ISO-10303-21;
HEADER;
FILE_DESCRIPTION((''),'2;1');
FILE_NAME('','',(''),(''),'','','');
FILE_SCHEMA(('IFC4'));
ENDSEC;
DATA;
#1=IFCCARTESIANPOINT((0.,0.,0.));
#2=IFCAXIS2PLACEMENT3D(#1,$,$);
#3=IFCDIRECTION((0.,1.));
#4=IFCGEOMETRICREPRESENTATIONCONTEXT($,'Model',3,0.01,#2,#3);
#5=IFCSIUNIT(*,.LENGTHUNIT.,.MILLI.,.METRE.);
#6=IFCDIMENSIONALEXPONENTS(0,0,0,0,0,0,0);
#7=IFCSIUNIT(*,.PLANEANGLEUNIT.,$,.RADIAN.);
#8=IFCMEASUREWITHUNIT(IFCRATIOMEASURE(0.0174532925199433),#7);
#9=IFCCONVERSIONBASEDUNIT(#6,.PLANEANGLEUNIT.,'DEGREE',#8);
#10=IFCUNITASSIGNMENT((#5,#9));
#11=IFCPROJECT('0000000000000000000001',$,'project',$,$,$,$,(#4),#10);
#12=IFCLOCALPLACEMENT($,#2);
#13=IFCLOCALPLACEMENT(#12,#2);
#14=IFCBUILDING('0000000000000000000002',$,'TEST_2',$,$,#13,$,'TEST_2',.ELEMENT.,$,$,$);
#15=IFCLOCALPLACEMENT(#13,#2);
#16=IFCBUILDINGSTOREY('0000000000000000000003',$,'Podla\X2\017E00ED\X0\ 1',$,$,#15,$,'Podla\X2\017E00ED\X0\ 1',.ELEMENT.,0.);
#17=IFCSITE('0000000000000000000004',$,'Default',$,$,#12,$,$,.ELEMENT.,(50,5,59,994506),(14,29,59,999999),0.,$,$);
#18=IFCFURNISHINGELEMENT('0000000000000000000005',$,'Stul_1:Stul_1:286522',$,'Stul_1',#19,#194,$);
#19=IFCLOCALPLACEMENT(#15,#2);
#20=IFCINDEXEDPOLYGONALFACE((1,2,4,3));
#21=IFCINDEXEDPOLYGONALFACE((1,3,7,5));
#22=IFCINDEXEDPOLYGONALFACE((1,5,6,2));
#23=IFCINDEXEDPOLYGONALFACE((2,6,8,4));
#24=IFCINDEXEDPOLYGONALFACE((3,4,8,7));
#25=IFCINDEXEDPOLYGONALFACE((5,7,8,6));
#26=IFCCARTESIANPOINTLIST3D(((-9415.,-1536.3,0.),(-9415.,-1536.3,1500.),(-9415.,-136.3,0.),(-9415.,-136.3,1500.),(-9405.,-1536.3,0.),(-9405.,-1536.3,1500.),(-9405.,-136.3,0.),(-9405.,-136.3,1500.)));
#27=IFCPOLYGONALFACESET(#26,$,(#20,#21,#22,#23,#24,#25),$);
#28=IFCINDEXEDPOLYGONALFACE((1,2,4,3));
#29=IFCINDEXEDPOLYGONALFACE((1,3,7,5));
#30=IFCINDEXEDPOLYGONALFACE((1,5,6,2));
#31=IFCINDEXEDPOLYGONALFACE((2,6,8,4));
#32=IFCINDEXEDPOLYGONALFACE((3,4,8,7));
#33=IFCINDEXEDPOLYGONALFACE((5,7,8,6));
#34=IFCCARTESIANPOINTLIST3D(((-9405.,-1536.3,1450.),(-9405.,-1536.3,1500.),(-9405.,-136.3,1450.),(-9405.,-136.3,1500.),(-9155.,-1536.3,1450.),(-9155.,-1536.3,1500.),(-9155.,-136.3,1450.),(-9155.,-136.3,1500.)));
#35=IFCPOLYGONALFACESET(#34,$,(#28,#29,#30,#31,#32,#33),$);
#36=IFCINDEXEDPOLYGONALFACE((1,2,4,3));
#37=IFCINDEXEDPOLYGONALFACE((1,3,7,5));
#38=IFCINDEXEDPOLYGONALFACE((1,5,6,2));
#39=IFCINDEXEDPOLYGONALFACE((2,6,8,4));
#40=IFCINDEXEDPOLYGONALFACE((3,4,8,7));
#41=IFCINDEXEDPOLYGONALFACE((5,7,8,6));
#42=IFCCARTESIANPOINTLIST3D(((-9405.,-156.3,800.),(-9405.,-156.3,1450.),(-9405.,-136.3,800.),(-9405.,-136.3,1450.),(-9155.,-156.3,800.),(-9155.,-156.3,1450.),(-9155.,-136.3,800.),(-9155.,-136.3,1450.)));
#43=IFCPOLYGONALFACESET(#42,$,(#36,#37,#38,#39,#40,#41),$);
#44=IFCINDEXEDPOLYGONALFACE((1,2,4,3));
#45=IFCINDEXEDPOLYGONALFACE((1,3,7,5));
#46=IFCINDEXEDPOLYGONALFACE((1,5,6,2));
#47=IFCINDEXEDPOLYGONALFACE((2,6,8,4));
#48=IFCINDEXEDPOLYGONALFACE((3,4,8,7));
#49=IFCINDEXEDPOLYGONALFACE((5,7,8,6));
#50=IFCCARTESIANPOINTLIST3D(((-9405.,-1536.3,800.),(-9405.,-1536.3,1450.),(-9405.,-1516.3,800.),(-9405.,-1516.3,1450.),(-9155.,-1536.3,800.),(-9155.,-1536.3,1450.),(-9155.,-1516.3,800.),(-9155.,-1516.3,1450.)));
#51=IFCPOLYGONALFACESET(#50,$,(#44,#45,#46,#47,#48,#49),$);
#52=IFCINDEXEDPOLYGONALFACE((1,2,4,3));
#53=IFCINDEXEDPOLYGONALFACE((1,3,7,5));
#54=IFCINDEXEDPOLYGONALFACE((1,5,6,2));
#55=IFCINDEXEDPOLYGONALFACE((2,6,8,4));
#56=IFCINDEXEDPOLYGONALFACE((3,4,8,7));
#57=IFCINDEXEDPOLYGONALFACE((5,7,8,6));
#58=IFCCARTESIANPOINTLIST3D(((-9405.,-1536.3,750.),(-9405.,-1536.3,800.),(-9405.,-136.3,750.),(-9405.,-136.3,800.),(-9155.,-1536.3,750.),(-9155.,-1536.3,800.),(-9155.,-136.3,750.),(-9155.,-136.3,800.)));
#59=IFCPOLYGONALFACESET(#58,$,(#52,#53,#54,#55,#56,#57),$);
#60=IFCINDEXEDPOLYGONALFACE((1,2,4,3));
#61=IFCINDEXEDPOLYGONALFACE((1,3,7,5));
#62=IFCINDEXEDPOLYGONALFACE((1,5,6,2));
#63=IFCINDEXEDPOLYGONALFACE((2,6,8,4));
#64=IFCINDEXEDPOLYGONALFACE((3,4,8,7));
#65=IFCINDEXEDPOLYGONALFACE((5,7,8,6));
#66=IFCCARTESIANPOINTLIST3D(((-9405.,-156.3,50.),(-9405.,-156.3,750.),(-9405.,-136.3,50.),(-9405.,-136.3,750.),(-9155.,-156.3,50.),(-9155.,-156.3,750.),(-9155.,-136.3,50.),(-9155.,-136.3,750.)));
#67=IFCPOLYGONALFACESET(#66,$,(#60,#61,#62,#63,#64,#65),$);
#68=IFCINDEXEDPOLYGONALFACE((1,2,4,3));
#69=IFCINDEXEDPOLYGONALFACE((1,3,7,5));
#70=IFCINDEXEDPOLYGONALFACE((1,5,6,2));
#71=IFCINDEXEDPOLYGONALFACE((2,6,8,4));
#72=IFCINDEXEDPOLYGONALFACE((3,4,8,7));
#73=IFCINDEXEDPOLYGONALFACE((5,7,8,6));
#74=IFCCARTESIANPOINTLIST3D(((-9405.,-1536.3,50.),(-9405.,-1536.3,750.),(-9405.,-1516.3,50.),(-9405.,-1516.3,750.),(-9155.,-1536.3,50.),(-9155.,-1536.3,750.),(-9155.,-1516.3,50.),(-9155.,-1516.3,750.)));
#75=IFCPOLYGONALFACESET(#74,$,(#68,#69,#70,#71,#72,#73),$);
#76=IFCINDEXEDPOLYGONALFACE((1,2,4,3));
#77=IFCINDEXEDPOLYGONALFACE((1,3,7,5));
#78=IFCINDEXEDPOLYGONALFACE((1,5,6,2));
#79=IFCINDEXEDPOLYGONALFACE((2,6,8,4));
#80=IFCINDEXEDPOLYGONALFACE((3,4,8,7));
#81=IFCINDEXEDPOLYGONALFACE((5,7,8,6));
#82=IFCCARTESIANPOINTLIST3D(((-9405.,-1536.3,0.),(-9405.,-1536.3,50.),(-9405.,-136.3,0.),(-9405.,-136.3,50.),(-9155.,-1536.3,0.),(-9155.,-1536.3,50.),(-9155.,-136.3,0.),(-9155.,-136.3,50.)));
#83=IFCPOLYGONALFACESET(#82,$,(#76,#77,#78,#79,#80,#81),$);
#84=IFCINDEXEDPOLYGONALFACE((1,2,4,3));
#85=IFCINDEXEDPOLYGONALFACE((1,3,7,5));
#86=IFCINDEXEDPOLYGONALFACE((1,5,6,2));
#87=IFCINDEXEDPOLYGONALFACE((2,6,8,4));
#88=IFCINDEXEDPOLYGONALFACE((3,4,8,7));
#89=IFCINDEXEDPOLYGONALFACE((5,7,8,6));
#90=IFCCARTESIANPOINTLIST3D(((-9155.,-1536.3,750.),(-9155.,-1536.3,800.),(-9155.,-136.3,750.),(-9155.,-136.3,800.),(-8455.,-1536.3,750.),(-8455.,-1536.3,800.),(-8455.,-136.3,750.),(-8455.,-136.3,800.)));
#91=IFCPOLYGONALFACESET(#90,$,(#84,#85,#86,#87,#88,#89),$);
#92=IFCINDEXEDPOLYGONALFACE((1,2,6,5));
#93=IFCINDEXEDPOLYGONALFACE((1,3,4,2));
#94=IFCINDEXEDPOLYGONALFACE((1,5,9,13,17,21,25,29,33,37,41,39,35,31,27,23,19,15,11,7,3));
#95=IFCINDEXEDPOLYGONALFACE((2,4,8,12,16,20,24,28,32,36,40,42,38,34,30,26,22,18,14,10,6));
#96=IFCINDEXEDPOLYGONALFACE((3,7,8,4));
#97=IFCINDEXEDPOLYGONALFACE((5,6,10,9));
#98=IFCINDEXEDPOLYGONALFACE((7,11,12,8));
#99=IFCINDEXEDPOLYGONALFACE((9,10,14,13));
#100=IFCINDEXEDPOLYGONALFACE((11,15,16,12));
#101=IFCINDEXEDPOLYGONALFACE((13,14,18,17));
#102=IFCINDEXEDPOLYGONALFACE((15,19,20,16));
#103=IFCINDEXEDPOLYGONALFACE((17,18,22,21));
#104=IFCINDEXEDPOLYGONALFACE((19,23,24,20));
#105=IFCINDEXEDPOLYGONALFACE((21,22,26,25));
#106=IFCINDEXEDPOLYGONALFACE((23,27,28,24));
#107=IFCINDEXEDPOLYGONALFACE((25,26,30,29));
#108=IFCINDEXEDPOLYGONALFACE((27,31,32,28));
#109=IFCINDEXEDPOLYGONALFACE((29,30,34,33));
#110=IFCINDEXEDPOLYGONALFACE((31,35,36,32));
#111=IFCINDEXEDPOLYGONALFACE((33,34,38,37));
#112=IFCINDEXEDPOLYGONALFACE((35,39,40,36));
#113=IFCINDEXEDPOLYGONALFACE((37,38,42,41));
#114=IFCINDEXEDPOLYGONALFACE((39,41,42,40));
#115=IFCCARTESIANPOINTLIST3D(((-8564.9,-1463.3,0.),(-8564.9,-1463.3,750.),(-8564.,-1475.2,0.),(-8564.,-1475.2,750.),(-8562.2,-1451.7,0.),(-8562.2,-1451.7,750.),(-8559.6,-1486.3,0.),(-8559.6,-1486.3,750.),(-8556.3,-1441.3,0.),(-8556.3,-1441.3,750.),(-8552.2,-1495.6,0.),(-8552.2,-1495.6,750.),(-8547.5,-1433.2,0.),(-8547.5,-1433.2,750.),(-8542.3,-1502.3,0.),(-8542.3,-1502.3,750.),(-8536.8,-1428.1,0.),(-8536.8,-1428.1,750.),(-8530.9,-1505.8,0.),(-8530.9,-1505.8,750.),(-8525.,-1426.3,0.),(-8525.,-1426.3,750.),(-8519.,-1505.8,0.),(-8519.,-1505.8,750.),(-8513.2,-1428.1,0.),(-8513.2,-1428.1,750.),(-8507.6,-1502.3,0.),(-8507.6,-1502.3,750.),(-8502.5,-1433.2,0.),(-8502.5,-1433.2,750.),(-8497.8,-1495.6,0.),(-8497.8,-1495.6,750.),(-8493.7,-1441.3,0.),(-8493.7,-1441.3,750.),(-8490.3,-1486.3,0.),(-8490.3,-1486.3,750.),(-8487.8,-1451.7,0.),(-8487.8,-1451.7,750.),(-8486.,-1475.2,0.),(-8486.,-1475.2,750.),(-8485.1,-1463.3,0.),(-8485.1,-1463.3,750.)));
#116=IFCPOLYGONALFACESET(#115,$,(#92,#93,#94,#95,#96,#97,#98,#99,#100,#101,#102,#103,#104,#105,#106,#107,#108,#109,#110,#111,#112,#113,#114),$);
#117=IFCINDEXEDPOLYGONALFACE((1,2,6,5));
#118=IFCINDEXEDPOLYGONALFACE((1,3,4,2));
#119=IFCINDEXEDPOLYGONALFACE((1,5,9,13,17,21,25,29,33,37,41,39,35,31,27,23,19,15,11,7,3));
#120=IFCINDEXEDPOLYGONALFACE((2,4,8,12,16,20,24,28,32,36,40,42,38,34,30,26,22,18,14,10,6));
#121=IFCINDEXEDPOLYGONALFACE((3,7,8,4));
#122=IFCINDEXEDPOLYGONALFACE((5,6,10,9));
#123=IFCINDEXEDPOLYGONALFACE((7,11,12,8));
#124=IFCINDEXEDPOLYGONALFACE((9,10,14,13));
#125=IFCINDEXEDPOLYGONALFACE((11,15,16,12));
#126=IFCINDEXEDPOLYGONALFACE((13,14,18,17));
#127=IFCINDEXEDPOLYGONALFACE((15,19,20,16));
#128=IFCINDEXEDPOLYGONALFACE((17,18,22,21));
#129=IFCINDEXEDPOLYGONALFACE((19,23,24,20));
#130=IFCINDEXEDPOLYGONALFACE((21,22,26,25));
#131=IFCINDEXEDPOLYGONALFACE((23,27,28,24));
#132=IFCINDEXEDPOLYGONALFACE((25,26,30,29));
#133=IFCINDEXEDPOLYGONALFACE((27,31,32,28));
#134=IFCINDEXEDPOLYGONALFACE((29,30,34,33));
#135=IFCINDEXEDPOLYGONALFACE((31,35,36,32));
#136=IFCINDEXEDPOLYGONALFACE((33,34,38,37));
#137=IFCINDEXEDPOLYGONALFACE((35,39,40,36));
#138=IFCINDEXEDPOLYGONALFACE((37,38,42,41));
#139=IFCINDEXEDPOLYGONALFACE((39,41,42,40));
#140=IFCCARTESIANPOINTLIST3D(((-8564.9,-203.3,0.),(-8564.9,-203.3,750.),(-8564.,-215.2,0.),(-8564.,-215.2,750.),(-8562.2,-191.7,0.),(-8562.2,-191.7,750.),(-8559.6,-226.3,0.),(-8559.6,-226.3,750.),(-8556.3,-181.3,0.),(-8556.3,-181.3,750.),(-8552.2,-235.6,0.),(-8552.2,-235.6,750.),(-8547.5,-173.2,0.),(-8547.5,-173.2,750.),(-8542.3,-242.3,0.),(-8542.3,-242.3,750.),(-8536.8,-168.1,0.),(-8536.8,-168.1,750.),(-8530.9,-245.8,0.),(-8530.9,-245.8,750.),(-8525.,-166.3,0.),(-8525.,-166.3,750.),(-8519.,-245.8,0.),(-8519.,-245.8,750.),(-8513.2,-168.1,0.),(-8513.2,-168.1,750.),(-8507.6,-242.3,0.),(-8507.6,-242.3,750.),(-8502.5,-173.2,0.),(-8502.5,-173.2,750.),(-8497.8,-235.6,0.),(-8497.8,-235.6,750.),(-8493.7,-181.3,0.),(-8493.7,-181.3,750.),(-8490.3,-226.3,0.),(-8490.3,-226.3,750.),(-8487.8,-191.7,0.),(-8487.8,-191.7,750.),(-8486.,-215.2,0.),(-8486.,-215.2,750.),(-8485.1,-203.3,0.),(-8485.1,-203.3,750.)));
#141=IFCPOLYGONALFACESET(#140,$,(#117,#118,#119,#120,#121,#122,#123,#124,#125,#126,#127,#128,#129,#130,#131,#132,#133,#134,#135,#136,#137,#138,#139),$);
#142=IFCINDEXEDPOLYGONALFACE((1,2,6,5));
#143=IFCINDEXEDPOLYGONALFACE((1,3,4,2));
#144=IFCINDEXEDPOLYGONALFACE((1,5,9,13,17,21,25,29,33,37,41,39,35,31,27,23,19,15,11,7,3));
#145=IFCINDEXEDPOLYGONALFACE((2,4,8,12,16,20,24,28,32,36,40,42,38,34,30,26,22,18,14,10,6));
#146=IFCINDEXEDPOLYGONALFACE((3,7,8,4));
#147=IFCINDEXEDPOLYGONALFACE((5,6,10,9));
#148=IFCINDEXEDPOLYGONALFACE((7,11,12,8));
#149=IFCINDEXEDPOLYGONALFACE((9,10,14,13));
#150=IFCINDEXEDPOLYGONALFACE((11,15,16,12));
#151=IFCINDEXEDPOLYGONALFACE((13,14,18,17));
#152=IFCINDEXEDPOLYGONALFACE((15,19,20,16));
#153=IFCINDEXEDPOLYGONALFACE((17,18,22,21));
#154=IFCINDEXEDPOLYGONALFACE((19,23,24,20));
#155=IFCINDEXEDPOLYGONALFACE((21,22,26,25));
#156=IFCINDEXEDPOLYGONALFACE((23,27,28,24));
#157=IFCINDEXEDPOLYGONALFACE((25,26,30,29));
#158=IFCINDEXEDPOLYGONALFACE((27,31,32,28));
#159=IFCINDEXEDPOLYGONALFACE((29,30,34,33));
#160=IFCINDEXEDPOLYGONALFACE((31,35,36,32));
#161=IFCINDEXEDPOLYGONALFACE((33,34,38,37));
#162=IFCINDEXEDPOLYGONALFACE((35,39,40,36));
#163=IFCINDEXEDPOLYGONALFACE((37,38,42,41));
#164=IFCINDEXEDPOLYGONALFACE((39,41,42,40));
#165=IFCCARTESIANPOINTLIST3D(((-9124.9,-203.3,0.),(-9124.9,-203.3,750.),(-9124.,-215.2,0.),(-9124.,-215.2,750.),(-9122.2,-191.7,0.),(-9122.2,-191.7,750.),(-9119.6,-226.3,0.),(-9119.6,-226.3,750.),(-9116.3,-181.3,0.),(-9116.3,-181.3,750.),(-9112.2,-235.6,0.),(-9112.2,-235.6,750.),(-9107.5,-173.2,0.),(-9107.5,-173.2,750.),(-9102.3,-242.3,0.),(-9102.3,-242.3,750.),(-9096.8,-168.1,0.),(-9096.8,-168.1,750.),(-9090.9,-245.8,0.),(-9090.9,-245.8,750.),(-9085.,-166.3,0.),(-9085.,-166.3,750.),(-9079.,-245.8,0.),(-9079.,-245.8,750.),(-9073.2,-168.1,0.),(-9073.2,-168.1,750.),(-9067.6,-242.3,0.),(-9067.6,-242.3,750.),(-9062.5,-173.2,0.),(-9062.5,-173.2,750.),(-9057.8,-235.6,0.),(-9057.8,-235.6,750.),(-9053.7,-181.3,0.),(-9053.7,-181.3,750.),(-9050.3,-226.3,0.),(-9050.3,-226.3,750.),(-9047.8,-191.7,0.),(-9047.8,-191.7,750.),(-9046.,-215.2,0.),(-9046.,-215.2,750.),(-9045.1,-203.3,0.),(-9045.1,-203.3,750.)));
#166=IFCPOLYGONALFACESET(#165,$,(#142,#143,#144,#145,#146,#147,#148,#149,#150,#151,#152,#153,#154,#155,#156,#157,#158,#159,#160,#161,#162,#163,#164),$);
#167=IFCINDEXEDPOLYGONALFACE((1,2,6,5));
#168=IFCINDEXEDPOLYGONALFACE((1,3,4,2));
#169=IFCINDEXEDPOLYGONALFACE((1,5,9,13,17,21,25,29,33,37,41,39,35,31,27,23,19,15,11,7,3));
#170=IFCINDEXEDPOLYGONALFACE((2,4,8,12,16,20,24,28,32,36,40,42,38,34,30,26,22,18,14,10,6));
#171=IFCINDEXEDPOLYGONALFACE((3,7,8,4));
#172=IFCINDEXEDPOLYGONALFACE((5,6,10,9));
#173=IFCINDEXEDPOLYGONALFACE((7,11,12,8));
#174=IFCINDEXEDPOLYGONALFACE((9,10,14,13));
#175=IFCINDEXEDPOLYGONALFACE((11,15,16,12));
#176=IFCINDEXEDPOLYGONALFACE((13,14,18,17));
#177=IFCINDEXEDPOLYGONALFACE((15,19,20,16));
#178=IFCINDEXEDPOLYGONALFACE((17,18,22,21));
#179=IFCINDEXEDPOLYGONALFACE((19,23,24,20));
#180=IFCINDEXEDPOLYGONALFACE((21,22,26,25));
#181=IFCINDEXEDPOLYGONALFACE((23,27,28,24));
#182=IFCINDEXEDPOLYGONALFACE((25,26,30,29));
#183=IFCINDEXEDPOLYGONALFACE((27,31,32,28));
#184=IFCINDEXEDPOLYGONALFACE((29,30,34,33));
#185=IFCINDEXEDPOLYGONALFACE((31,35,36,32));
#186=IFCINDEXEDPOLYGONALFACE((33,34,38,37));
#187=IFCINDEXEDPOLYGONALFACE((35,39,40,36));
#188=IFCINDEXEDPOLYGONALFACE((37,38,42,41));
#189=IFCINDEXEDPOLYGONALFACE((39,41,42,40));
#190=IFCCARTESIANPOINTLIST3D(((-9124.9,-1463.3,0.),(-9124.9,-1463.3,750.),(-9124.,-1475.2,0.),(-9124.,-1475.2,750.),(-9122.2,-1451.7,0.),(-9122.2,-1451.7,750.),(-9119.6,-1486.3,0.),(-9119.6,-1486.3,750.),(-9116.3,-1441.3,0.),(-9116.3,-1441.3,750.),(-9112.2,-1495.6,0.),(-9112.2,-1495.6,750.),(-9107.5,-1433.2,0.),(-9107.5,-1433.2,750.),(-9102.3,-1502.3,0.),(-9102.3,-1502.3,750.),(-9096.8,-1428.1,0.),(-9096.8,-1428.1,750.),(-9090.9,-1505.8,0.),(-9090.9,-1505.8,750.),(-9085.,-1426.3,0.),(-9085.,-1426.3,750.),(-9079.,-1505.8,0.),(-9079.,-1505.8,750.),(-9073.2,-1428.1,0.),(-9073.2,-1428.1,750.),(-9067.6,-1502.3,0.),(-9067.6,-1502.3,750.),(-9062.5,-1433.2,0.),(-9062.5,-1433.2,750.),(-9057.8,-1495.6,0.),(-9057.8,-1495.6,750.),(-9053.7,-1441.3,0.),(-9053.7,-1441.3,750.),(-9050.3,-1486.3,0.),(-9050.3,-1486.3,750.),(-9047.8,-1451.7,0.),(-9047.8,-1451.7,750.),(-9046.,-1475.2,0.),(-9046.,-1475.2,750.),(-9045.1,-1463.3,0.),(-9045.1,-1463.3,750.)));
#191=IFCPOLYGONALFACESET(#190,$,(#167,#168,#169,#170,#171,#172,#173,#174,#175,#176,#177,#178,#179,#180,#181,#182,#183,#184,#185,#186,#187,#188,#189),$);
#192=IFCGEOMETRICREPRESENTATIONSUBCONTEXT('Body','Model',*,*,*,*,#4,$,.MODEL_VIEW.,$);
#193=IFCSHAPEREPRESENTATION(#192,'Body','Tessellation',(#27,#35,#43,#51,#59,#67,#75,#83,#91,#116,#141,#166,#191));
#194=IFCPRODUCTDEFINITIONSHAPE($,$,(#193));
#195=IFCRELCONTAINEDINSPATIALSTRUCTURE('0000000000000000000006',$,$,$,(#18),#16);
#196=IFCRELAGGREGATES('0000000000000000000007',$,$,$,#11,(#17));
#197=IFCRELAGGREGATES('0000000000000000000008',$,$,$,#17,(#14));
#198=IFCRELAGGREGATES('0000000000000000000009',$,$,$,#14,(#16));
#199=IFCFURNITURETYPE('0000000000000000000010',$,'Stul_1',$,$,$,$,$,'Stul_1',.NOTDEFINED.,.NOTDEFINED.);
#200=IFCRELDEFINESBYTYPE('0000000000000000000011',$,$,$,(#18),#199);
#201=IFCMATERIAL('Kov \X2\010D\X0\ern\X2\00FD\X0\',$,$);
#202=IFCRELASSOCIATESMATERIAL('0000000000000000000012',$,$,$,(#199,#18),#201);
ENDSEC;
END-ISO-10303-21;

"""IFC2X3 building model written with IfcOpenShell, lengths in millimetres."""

from ifc_helpers import new_model, entity, si_unit, converted_unit, direction, frame, frame_2d, origin, origin_2d_with_axis, place, context, subcontext, project, spatial, rectangle, circle, extrude, source, transform, mapped, material, type_object, type_shapes, element, save


model = new_model("IFC2X3")

# Units and contexts
model_context = context("Model", 3, precision=0.01, world=origin(), true_north=direction((0.0, 1.0)))
body_context = subcontext(model_context, "Body", "Model", "MODEL_VIEW")
ifc_project = project(units=[si_unit("LENGTHUNIT", "METRE", prefix="MILLI"), converted_unit("PLANEANGLEUNIT", "DEGREE", entity("IfcRatioMeasure", 0.0174532925199433), si_unit("PLANEANGLEUNIT", "RADIAN"), dimensions=[0, 0, 0, 0, 0, 0, 0])], contexts=[model_context])

# Site, building, storey
site_placement = place(None, origin())
site = spatial("IfcSite", under=ifc_project, at=site_placement, Name="Default", CompositionType="ELEMENT", RefLatitude=(50, 5, 59, 994506), RefLongitude=(14, 29, 59, 999999), RefElevation=0.0)
building_placement = place(site_placement, origin())
building = spatial("IfcBuilding", under=site, at=building_placement, Name="TEST_2", LongName="TEST_2", CompositionType="ELEMENT")
storey_placement = place(building_placement, origin())
storey = spatial("IfcBuildingStorey", under=building, at=storey_placement, Name="Podlaží 1", LongName="Podlaží 1", CompositionType="ELEMENT", Elevation=0.0)

# Furnishing element
ifc_material_1 = material(Name="Kov černý")
furniture_type = type_object("IfcFurnitureType", Name="Stul_1", ElementType="Stul_1", material=ifc_material_1)
shared_shape_1 = source(origin(), body_context, "Body", "SweptSolid", [
    extrude(rectangle(XDim=1400.0, YDim=10.0, at=origin_2d_with_axis()), frame((0.0, 605.0, 0.0), z_axis=(0.0, 0.0, 1.0), x_axis=(-1.0, 0.0, 0.0)), (0.0, 0.0, 1.0), 1500.0),
    extrude(rectangle(XDim=1400.0, YDim=250.0, at=frame_2d((0.0, 0.0), x_axis=(1.0, 0.0))), frame((0.0, 475.0, 1450.0), z_axis=(0.0, 0.0, 1.0), x_axis=(-1.0, 0.0, 0.0)), (0.0, 0.0, 1.0), 50.0),
    extrude(rectangle(XDim=20.0, YDim=250.0, at=origin_2d_with_axis()), frame((690.0, 475.0, 800.0), z_axis=(0.0, 0.0, 1.0), x_axis=(-1.0, 0.0, 0.0)), (0.0, 0.0, 1.0), 650.0),
    extrude(rectangle(XDim=20.0, YDim=250.0, at=frame_2d((0.0, 0.0), x_axis=(1.0, 0.0))), frame((-690.0, 475.0, 800.0), z_axis=(0.0, 0.0, 1.0), x_axis=(-1.0, 0.0, 0.0)), (0.0, 0.0, 1.0), 650.0),
    extrude(rectangle(XDim=1400.0, YDim=250.0, at=origin_2d_with_axis()), frame((0.0, 475.0, 750.0), z_axis=(0.0, 0.0, 1.0), x_axis=(-1.0, 0.0, 0.0)), (0.0, 0.0, 1.0), 50.0),
    extrude(rectangle(XDim=20.0, YDim=250.0, at=origin_2d_with_axis()), frame((690.0, 475.0, 50.0), z_axis=(0.0, 0.0, 1.0), x_axis=(-1.0, 0.0, 0.0)), (0.0, 0.0, 1.0), 700.0),
    extrude(rectangle(XDim=20.0, YDim=250.0, at=frame_2d((0.0, 0.0), x_axis=(1.0, 0.0))), frame((-690.0, 475.0, 50.0), z_axis=(0.0, 0.0, 1.0), x_axis=(-1.0, 0.0, 0.0)), (0.0, 0.0, 1.0), 700.0),
    extrude(rectangle(XDim=1400.0, YDim=250.0, at=origin_2d_with_axis()), frame((0.0, 475.0, 0.0), z_axis=(0.0, 0.0, 1.0), x_axis=(-1.0, 0.0, 0.0)), (0.0, 0.0, 1.0), 50.0),
    extrude(rectangle(XDim=1400.0, YDim=700.0, at=origin_2d_with_axis()), frame((0.0, 0.0, 750.0), z_axis=(0.0, 0.0, 1.0), x_axis=(-1.0, 0.0, 0.0)), (0.0, 0.0, 1.0), 50.0),
    extrude(circle(Radius=40.0, at=frame_2d((0.0, 0.0), x_axis=(1.0, 0.0))), frame((-630.0, -280.0, 0.0)), (0.0, 0.0, 1.0), 750.0),
    extrude(circle(Radius=40.0, at=frame_2d((0.0, 0.0), x_axis=(1.0, 0.0))), frame((630.0, -280.0, 0.0)), (0.0, 0.0, 1.0), 750.0),
    extrude(circle(Radius=40.0, at=frame_2d((0.0, 0.0), x_axis=(1.0, 0.0))), frame((630.0, 280.0, 0.0)), (0.0, 0.0, 1.0), 750.0),
    extrude(circle(Radius=40.0, at=frame_2d((0.0, 0.0), x_axis=(1.0, 0.0))), frame((-630.0, 280.0, 0.0)), (0.0, 0.0, 1.0), 750.0),
])
type_shapes(furniture_type, [shared_shape_1])
for number, where, z_axis, x_axis, name in (
    (1, (-8805.0, -836.3, 0.0), (0.0, 0.0, 1.0), (0.0, 1.0, 0.0), "Stul_1:Stul_1:286522"),
):
    element("IfcFurnishingElement", number, at=place(storey_placement, frame(where, z_axis=z_axis, x_axis=x_axis)), inside=storey, type_object=furniture_type, material=ifc_material_1, Name=name, ObjectType="Stul_1", context=body_context, shape_type="MappedRepresentation", body=[
        mapped(shared_shape_1, transform((0.0, 0.0, 0.0), scale=1.0)),
    ])

save(model, "model.ifc")
